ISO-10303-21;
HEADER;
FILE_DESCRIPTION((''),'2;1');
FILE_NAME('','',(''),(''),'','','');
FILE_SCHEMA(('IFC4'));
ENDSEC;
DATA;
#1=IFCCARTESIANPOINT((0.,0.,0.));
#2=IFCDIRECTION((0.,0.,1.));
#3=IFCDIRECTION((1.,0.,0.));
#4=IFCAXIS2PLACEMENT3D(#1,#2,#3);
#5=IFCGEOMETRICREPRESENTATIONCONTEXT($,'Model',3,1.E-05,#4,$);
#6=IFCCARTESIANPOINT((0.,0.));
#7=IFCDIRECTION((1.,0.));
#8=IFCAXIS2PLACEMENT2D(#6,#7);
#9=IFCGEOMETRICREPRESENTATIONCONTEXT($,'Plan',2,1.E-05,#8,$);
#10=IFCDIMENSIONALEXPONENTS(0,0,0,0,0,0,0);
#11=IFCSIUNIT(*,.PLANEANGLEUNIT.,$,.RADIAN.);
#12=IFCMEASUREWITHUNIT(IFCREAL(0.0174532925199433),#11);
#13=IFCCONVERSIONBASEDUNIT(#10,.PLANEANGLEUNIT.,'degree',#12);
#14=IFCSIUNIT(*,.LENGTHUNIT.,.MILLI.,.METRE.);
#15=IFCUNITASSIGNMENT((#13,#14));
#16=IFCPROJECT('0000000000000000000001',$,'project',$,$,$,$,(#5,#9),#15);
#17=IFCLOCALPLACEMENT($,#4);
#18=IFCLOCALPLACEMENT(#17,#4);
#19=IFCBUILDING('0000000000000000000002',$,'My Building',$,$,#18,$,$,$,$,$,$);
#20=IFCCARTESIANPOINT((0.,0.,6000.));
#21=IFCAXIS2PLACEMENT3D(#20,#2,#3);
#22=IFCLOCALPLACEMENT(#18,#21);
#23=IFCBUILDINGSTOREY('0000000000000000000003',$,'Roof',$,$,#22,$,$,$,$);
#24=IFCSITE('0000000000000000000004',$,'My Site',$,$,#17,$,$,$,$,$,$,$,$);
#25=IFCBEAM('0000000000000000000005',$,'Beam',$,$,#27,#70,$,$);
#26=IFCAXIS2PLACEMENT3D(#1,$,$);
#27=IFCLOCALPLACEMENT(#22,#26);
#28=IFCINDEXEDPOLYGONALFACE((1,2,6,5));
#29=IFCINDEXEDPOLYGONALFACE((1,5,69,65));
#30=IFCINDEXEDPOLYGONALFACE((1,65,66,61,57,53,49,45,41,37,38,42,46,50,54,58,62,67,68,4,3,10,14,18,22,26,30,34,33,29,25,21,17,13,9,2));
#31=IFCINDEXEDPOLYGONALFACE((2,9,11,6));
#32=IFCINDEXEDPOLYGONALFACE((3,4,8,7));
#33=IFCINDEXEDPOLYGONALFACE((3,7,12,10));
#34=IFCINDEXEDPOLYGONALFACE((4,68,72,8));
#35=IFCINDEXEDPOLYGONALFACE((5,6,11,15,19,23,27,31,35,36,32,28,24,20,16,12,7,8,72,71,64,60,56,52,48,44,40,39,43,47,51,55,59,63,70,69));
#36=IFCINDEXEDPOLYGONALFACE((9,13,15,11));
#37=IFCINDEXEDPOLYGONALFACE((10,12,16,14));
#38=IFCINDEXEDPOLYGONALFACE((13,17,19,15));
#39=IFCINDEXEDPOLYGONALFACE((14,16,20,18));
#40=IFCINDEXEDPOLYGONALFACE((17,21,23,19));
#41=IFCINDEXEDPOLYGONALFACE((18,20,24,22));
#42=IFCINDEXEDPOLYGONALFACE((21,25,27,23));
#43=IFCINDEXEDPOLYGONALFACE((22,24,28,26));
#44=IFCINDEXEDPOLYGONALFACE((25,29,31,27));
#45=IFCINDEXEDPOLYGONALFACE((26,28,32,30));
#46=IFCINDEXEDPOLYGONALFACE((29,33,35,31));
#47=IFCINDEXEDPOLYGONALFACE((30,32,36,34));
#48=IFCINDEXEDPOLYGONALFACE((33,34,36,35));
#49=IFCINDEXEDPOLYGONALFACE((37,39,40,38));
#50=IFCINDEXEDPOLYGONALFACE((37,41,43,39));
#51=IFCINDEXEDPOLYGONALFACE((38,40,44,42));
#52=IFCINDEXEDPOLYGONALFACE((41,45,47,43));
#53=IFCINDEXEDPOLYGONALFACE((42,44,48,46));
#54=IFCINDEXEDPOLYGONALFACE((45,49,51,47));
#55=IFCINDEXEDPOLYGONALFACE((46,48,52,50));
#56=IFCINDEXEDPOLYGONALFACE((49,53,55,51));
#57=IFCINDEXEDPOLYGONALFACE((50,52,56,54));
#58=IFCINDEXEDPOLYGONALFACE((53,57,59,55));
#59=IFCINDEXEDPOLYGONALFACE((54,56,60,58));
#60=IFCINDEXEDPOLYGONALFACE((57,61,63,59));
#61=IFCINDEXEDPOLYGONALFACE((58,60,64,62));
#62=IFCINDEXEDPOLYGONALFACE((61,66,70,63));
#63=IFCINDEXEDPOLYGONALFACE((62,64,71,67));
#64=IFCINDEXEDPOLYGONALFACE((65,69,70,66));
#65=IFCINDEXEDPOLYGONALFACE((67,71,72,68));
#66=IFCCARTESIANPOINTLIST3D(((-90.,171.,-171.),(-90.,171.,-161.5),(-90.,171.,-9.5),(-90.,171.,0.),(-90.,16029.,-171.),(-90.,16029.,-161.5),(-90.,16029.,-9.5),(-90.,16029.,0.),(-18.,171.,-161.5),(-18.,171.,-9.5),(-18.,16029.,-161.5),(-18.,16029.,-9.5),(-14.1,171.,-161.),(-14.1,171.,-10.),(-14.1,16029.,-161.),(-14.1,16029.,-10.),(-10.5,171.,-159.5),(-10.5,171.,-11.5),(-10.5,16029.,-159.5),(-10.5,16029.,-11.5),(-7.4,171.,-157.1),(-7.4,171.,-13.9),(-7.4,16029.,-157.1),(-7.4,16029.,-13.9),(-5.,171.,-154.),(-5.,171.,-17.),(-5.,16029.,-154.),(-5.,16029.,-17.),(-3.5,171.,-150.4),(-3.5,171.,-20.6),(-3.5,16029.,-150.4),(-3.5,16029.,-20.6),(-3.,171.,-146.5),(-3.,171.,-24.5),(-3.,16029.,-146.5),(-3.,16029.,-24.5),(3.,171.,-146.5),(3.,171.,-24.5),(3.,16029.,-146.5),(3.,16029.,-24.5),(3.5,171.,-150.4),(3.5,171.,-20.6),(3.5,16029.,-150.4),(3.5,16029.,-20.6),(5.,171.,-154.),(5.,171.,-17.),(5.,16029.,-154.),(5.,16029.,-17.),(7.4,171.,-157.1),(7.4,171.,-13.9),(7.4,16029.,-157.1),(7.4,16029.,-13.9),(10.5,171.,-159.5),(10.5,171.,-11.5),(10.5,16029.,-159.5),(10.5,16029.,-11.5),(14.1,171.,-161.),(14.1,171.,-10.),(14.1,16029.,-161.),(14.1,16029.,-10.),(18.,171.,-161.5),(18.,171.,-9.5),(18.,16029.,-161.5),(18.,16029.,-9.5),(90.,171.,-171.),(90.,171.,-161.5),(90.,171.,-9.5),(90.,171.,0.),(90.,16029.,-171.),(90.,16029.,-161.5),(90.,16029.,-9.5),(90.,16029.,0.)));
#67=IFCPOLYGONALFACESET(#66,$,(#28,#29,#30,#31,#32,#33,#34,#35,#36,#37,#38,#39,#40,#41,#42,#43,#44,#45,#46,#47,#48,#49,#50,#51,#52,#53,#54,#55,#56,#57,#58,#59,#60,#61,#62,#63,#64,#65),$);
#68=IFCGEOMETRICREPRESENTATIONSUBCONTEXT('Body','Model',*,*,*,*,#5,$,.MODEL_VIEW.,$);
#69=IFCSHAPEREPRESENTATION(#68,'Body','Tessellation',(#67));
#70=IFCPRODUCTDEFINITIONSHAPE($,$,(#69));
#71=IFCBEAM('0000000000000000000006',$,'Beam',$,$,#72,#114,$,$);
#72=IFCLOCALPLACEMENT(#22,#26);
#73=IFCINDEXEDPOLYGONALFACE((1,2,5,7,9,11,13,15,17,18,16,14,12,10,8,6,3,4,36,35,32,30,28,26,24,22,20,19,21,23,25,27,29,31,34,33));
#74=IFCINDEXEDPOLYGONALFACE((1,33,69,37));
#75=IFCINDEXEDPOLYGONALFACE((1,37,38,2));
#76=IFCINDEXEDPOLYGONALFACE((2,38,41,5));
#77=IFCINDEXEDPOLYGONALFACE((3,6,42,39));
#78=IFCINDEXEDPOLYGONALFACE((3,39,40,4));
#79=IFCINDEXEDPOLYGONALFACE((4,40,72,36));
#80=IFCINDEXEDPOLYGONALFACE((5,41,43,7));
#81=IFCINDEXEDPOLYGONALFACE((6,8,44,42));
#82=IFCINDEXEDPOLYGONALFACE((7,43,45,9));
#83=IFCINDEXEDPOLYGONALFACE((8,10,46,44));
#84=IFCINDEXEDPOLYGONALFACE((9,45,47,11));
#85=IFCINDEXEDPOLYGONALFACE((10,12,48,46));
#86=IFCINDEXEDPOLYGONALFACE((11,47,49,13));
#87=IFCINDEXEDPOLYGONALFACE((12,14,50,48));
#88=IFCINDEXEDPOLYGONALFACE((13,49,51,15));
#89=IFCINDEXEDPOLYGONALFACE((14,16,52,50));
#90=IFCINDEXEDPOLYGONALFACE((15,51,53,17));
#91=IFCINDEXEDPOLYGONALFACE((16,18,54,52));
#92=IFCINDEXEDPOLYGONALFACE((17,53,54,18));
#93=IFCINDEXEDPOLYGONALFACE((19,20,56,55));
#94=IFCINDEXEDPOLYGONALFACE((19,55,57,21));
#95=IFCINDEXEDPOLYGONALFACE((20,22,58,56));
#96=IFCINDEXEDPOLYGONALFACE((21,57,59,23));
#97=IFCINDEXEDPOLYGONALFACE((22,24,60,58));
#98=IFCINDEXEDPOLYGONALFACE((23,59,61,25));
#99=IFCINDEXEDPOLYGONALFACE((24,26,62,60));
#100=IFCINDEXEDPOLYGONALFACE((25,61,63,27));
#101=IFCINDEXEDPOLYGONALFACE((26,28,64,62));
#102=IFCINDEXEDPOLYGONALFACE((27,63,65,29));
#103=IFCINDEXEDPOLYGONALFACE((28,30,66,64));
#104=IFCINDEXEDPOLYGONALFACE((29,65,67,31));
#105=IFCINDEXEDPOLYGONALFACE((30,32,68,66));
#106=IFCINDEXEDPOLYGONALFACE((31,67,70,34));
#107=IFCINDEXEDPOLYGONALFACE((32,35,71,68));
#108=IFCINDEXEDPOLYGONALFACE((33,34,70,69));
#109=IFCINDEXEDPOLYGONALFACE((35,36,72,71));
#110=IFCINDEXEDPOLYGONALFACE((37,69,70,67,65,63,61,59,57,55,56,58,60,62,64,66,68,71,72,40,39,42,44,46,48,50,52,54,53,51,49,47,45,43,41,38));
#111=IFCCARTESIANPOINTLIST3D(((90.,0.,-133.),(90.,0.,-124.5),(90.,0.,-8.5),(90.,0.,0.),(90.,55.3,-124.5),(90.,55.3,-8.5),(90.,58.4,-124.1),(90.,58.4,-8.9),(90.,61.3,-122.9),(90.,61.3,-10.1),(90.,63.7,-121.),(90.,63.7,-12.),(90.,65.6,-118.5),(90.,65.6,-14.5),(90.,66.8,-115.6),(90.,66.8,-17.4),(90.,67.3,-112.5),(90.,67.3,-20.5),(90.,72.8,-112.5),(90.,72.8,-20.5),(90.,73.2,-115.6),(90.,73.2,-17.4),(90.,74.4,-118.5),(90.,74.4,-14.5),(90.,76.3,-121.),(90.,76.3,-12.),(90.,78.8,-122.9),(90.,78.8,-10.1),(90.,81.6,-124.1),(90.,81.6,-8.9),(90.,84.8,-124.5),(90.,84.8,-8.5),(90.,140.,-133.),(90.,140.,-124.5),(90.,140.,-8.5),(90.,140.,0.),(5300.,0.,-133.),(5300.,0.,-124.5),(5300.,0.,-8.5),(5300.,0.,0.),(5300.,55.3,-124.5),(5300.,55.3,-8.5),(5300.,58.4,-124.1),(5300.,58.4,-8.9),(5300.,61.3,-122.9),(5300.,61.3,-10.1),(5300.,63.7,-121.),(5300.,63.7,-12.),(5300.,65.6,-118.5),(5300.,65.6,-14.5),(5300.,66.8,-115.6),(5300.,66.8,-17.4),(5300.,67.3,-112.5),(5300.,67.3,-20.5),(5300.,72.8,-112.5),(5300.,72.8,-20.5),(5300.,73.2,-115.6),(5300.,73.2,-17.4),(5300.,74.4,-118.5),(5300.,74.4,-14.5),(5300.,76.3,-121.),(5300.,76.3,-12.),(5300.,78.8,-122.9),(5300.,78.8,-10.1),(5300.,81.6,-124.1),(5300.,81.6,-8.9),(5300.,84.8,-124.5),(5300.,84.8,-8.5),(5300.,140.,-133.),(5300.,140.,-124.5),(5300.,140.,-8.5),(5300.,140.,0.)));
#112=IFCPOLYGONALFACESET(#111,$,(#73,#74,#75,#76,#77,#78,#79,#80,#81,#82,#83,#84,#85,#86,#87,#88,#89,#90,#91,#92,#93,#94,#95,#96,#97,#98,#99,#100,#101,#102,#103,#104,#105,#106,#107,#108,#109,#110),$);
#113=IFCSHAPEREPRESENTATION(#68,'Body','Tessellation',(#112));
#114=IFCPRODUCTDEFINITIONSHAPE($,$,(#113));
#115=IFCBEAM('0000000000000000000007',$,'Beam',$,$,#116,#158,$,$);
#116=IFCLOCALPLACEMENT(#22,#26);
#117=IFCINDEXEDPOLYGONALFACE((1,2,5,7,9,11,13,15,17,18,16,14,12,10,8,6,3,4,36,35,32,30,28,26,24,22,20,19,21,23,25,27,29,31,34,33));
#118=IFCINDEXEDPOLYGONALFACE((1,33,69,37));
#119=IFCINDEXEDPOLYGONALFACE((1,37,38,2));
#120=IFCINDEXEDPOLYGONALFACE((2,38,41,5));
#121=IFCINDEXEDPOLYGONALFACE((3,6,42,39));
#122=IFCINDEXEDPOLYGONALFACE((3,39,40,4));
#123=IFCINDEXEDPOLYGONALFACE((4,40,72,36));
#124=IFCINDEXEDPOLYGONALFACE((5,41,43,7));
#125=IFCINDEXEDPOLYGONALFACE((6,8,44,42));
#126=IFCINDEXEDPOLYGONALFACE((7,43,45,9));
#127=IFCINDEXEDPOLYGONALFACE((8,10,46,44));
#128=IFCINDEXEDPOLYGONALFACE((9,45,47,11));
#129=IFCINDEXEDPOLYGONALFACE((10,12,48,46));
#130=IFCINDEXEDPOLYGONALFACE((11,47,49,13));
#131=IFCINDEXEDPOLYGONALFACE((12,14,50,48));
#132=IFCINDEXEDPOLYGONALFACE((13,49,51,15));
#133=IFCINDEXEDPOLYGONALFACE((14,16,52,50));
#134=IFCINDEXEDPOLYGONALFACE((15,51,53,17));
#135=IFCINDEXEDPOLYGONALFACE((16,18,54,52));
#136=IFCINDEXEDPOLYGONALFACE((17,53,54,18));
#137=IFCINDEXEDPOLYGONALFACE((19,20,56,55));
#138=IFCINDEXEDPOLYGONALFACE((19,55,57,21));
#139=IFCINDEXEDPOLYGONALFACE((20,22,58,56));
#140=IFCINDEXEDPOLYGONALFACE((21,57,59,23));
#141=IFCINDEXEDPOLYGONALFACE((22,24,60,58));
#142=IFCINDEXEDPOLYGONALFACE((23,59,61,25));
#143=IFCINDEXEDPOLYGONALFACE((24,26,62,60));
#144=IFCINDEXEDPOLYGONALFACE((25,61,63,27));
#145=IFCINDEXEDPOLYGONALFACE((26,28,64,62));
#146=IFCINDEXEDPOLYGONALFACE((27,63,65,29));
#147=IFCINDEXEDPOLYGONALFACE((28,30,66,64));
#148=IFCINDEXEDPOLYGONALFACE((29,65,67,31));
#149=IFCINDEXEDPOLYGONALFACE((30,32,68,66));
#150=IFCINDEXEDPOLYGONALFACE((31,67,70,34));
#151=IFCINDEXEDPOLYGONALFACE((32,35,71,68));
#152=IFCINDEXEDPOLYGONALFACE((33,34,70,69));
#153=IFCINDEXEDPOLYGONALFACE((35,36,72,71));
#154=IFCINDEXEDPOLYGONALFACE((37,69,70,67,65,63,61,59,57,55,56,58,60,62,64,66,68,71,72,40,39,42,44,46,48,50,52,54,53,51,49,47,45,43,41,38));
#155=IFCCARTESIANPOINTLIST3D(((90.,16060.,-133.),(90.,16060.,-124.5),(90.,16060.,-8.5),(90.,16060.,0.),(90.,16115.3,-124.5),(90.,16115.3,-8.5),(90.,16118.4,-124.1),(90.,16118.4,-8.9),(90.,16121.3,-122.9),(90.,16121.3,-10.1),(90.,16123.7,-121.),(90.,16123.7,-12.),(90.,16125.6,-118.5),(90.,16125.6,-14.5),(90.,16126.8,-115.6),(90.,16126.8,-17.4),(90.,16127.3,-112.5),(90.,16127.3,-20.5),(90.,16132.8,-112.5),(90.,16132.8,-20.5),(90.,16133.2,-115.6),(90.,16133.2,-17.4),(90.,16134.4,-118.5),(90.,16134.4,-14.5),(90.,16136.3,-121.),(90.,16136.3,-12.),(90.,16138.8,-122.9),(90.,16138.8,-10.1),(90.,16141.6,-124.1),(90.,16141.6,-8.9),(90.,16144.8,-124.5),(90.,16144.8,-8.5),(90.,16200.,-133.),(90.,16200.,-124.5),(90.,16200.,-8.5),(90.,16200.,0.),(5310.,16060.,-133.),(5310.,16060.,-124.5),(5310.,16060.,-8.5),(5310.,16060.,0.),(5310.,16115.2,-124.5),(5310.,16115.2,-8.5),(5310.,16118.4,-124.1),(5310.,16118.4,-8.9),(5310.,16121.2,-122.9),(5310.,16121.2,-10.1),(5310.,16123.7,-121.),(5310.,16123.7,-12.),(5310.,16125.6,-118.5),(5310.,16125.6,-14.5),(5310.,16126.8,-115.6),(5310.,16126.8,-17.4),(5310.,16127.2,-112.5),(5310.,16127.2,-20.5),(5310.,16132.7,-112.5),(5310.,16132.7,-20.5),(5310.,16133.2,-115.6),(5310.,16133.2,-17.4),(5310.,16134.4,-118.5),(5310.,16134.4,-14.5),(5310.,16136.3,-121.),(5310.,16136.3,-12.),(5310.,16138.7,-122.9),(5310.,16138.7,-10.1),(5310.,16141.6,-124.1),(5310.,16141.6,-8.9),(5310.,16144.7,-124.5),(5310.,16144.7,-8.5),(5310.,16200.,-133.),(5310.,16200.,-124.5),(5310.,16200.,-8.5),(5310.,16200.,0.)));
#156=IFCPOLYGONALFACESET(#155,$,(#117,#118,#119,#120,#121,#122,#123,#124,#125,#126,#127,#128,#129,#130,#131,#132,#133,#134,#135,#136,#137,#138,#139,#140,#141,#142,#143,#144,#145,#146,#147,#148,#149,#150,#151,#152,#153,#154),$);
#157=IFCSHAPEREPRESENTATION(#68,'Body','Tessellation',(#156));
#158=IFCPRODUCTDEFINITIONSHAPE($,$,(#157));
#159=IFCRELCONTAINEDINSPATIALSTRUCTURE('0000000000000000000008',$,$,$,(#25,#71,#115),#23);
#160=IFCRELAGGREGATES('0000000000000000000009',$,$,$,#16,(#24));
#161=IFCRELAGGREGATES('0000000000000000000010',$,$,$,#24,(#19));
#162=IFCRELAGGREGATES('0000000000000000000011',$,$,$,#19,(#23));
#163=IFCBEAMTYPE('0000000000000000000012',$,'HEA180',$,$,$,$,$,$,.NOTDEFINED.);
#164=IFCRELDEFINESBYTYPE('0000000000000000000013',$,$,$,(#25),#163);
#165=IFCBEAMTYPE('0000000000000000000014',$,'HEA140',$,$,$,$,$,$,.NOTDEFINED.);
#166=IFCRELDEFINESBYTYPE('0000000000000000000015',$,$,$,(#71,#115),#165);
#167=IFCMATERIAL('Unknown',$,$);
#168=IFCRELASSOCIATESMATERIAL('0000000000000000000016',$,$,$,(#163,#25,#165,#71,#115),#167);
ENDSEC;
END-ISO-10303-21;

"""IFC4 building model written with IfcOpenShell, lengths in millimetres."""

from ifc_helpers import new_model, entity, si_unit, converted_unit, frame, origin_with_axes, origin_2d_with_axis, place, context, subcontext, project, spatial, i_section, extrude, material, material_profile, profile_set, profile_usage, type_object, element, save


model = new_model("IFC4")

# Units and contexts
model_context = context("Model", 3, precision=1e-05, world=origin_with_axes())
plan_context = context("Plan", 2, precision=1e-05, world=origin_2d_with_axis())
body_context = subcontext(model_context, "Body", "Model", "MODEL_VIEW")
ifc_project = project(units=[converted_unit("PLANEANGLEUNIT", "degree", entity("IfcReal", 0.0174532925199433), si_unit("PLANEANGLEUNIT", "RADIAN"), dimensions=[0, 0, 0, 0, 0, 0, 0]), si_unit("LENGTHUNIT", "METRE", prefix="MILLI")], contexts=[model_context, plan_context])

# Site, building, storey
site_placement = place(None, origin_with_axes())
site = spatial("IfcSite", under=ifc_project, at=site_placement, Name="My Site")
building_placement = place(site_placement, origin_with_axes())
building = spatial("IfcBuilding", under=site, at=building_placement, Name="My Building")
storey_placement = place(building_placement, frame((0.0, 0.0, 6000.0), z_axis=(0.0, 0.0, 1.0), x_axis=(1.0, 0.0, 0.0)))
storey = spatial("IfcBuildingStorey", under=building, at=storey_placement, Name="Roof")

# Beams
ifc_material = material(Name="Unknown")
ifc_material_profile_1 = material_profile(ifc_material, i_section(OverallWidth=180.0, OverallDepth=171.0, WebThickness=6.0, FlangeThickness=9.5, FilletRadius=15.0))
ifc_profile_set_1 = profile_set([ifc_material_profile_1])
ifc_profile_usage_1 = profile_usage(ifc_profile_set_1, cardinal=8)
beam_type_1 = type_object("IfcBeamType", Name="HEA180", PredefinedType="NOTDEFINED", material=ifc_profile_set_1)
beam_1_placement = place(storey_placement, frame((0.0, 171.0, 0.0), z_axis=(0.000001, 1.0, 0.0), x_axis=(-1.0, 0.000001, 0.0)))
element("IfcBeam", 1, at=beam_1_placement, inside=storey, type_object=beam_type_1, material=ifc_profile_usage_1, Name="Beam", context=body_context, shape_type="SweptSolid", body=[
    extrude(i_section(OverallWidth=180.0, OverallDepth=171.0, WebThickness=6.0, FlangeThickness=9.5, FilletRadius=15.0), frame((0.0, -85.5, 0.0), z_axis=(0.0, 0.0, 1.0), x_axis=(1.0, 0.0, 0.0)), (0.0, 0.0, 1.0), 15858.0),
])
ifc_material_profile_2 = material_profile(ifc_material, i_section(OverallWidth=140.0, OverallDepth=133.0, WebThickness=5.5, FlangeThickness=8.5, FilletRadius=12.0))
ifc_profile_set_2 = profile_set([ifc_material_profile_2])
ifc_profile_usage_2 = profile_usage(ifc_profile_set_2, cardinal=7)
beam_type_2 = type_object("IfcBeamType", Name="HEA140", PredefinedType="NOTDEFINED", material=ifc_profile_set_2)
beam_2_placement = place(storey_placement, frame((5300.0, 0.0, 0.0), z_axis=(-1.0, 0.0, 0.0), x_axis=(0.0, -1.0, 0.0)))
element("IfcBeam", 2, at=beam_2_placement, inside=storey, type_object=beam_type_2, material=ifc_profile_usage_2, Name="Beam", context=body_context, shape_type="SweptSolid", body=[
    extrude(i_section(OverallWidth=140.0, OverallDepth=133.0, WebThickness=5.5, FlangeThickness=8.5, FilletRadius=12.0), frame((-70.0, -66.5, 0.0), z_axis=(0.0, 0.0, 1.0), x_axis=(1.0, 0.0, 0.0)), (0.0, 0.0, 1.0), 5210.0),
])
ifc_profile_usage_3 = profile_usage(ifc_profile_set_2, cardinal=7)
beam_3_placement = place(storey_placement, frame((90.0, 16200.0, 0.0), z_axis=(1.0, 0.0, 0.0), x_axis=(0.0, 1.0, 0.0)))
element("IfcBeam", 3, at=beam_3_placement, inside=storey, type_object=beam_type_2, material=ifc_profile_usage_3, Name="Beam", context=body_context, shape_type="SweptSolid", body=[
    extrude(i_section(OverallWidth=140.0, OverallDepth=133.0, WebThickness=5.5, FlangeThickness=8.5, FilletRadius=12.0), frame((-70.0, -66.5, 0.0), z_axis=(0.0, 0.0, 1.0), x_axis=(1.0, 0.0, 0.0)), (0.0, 0.0, 1.0), 5220.0),
])

save(model, "model.ifc")
